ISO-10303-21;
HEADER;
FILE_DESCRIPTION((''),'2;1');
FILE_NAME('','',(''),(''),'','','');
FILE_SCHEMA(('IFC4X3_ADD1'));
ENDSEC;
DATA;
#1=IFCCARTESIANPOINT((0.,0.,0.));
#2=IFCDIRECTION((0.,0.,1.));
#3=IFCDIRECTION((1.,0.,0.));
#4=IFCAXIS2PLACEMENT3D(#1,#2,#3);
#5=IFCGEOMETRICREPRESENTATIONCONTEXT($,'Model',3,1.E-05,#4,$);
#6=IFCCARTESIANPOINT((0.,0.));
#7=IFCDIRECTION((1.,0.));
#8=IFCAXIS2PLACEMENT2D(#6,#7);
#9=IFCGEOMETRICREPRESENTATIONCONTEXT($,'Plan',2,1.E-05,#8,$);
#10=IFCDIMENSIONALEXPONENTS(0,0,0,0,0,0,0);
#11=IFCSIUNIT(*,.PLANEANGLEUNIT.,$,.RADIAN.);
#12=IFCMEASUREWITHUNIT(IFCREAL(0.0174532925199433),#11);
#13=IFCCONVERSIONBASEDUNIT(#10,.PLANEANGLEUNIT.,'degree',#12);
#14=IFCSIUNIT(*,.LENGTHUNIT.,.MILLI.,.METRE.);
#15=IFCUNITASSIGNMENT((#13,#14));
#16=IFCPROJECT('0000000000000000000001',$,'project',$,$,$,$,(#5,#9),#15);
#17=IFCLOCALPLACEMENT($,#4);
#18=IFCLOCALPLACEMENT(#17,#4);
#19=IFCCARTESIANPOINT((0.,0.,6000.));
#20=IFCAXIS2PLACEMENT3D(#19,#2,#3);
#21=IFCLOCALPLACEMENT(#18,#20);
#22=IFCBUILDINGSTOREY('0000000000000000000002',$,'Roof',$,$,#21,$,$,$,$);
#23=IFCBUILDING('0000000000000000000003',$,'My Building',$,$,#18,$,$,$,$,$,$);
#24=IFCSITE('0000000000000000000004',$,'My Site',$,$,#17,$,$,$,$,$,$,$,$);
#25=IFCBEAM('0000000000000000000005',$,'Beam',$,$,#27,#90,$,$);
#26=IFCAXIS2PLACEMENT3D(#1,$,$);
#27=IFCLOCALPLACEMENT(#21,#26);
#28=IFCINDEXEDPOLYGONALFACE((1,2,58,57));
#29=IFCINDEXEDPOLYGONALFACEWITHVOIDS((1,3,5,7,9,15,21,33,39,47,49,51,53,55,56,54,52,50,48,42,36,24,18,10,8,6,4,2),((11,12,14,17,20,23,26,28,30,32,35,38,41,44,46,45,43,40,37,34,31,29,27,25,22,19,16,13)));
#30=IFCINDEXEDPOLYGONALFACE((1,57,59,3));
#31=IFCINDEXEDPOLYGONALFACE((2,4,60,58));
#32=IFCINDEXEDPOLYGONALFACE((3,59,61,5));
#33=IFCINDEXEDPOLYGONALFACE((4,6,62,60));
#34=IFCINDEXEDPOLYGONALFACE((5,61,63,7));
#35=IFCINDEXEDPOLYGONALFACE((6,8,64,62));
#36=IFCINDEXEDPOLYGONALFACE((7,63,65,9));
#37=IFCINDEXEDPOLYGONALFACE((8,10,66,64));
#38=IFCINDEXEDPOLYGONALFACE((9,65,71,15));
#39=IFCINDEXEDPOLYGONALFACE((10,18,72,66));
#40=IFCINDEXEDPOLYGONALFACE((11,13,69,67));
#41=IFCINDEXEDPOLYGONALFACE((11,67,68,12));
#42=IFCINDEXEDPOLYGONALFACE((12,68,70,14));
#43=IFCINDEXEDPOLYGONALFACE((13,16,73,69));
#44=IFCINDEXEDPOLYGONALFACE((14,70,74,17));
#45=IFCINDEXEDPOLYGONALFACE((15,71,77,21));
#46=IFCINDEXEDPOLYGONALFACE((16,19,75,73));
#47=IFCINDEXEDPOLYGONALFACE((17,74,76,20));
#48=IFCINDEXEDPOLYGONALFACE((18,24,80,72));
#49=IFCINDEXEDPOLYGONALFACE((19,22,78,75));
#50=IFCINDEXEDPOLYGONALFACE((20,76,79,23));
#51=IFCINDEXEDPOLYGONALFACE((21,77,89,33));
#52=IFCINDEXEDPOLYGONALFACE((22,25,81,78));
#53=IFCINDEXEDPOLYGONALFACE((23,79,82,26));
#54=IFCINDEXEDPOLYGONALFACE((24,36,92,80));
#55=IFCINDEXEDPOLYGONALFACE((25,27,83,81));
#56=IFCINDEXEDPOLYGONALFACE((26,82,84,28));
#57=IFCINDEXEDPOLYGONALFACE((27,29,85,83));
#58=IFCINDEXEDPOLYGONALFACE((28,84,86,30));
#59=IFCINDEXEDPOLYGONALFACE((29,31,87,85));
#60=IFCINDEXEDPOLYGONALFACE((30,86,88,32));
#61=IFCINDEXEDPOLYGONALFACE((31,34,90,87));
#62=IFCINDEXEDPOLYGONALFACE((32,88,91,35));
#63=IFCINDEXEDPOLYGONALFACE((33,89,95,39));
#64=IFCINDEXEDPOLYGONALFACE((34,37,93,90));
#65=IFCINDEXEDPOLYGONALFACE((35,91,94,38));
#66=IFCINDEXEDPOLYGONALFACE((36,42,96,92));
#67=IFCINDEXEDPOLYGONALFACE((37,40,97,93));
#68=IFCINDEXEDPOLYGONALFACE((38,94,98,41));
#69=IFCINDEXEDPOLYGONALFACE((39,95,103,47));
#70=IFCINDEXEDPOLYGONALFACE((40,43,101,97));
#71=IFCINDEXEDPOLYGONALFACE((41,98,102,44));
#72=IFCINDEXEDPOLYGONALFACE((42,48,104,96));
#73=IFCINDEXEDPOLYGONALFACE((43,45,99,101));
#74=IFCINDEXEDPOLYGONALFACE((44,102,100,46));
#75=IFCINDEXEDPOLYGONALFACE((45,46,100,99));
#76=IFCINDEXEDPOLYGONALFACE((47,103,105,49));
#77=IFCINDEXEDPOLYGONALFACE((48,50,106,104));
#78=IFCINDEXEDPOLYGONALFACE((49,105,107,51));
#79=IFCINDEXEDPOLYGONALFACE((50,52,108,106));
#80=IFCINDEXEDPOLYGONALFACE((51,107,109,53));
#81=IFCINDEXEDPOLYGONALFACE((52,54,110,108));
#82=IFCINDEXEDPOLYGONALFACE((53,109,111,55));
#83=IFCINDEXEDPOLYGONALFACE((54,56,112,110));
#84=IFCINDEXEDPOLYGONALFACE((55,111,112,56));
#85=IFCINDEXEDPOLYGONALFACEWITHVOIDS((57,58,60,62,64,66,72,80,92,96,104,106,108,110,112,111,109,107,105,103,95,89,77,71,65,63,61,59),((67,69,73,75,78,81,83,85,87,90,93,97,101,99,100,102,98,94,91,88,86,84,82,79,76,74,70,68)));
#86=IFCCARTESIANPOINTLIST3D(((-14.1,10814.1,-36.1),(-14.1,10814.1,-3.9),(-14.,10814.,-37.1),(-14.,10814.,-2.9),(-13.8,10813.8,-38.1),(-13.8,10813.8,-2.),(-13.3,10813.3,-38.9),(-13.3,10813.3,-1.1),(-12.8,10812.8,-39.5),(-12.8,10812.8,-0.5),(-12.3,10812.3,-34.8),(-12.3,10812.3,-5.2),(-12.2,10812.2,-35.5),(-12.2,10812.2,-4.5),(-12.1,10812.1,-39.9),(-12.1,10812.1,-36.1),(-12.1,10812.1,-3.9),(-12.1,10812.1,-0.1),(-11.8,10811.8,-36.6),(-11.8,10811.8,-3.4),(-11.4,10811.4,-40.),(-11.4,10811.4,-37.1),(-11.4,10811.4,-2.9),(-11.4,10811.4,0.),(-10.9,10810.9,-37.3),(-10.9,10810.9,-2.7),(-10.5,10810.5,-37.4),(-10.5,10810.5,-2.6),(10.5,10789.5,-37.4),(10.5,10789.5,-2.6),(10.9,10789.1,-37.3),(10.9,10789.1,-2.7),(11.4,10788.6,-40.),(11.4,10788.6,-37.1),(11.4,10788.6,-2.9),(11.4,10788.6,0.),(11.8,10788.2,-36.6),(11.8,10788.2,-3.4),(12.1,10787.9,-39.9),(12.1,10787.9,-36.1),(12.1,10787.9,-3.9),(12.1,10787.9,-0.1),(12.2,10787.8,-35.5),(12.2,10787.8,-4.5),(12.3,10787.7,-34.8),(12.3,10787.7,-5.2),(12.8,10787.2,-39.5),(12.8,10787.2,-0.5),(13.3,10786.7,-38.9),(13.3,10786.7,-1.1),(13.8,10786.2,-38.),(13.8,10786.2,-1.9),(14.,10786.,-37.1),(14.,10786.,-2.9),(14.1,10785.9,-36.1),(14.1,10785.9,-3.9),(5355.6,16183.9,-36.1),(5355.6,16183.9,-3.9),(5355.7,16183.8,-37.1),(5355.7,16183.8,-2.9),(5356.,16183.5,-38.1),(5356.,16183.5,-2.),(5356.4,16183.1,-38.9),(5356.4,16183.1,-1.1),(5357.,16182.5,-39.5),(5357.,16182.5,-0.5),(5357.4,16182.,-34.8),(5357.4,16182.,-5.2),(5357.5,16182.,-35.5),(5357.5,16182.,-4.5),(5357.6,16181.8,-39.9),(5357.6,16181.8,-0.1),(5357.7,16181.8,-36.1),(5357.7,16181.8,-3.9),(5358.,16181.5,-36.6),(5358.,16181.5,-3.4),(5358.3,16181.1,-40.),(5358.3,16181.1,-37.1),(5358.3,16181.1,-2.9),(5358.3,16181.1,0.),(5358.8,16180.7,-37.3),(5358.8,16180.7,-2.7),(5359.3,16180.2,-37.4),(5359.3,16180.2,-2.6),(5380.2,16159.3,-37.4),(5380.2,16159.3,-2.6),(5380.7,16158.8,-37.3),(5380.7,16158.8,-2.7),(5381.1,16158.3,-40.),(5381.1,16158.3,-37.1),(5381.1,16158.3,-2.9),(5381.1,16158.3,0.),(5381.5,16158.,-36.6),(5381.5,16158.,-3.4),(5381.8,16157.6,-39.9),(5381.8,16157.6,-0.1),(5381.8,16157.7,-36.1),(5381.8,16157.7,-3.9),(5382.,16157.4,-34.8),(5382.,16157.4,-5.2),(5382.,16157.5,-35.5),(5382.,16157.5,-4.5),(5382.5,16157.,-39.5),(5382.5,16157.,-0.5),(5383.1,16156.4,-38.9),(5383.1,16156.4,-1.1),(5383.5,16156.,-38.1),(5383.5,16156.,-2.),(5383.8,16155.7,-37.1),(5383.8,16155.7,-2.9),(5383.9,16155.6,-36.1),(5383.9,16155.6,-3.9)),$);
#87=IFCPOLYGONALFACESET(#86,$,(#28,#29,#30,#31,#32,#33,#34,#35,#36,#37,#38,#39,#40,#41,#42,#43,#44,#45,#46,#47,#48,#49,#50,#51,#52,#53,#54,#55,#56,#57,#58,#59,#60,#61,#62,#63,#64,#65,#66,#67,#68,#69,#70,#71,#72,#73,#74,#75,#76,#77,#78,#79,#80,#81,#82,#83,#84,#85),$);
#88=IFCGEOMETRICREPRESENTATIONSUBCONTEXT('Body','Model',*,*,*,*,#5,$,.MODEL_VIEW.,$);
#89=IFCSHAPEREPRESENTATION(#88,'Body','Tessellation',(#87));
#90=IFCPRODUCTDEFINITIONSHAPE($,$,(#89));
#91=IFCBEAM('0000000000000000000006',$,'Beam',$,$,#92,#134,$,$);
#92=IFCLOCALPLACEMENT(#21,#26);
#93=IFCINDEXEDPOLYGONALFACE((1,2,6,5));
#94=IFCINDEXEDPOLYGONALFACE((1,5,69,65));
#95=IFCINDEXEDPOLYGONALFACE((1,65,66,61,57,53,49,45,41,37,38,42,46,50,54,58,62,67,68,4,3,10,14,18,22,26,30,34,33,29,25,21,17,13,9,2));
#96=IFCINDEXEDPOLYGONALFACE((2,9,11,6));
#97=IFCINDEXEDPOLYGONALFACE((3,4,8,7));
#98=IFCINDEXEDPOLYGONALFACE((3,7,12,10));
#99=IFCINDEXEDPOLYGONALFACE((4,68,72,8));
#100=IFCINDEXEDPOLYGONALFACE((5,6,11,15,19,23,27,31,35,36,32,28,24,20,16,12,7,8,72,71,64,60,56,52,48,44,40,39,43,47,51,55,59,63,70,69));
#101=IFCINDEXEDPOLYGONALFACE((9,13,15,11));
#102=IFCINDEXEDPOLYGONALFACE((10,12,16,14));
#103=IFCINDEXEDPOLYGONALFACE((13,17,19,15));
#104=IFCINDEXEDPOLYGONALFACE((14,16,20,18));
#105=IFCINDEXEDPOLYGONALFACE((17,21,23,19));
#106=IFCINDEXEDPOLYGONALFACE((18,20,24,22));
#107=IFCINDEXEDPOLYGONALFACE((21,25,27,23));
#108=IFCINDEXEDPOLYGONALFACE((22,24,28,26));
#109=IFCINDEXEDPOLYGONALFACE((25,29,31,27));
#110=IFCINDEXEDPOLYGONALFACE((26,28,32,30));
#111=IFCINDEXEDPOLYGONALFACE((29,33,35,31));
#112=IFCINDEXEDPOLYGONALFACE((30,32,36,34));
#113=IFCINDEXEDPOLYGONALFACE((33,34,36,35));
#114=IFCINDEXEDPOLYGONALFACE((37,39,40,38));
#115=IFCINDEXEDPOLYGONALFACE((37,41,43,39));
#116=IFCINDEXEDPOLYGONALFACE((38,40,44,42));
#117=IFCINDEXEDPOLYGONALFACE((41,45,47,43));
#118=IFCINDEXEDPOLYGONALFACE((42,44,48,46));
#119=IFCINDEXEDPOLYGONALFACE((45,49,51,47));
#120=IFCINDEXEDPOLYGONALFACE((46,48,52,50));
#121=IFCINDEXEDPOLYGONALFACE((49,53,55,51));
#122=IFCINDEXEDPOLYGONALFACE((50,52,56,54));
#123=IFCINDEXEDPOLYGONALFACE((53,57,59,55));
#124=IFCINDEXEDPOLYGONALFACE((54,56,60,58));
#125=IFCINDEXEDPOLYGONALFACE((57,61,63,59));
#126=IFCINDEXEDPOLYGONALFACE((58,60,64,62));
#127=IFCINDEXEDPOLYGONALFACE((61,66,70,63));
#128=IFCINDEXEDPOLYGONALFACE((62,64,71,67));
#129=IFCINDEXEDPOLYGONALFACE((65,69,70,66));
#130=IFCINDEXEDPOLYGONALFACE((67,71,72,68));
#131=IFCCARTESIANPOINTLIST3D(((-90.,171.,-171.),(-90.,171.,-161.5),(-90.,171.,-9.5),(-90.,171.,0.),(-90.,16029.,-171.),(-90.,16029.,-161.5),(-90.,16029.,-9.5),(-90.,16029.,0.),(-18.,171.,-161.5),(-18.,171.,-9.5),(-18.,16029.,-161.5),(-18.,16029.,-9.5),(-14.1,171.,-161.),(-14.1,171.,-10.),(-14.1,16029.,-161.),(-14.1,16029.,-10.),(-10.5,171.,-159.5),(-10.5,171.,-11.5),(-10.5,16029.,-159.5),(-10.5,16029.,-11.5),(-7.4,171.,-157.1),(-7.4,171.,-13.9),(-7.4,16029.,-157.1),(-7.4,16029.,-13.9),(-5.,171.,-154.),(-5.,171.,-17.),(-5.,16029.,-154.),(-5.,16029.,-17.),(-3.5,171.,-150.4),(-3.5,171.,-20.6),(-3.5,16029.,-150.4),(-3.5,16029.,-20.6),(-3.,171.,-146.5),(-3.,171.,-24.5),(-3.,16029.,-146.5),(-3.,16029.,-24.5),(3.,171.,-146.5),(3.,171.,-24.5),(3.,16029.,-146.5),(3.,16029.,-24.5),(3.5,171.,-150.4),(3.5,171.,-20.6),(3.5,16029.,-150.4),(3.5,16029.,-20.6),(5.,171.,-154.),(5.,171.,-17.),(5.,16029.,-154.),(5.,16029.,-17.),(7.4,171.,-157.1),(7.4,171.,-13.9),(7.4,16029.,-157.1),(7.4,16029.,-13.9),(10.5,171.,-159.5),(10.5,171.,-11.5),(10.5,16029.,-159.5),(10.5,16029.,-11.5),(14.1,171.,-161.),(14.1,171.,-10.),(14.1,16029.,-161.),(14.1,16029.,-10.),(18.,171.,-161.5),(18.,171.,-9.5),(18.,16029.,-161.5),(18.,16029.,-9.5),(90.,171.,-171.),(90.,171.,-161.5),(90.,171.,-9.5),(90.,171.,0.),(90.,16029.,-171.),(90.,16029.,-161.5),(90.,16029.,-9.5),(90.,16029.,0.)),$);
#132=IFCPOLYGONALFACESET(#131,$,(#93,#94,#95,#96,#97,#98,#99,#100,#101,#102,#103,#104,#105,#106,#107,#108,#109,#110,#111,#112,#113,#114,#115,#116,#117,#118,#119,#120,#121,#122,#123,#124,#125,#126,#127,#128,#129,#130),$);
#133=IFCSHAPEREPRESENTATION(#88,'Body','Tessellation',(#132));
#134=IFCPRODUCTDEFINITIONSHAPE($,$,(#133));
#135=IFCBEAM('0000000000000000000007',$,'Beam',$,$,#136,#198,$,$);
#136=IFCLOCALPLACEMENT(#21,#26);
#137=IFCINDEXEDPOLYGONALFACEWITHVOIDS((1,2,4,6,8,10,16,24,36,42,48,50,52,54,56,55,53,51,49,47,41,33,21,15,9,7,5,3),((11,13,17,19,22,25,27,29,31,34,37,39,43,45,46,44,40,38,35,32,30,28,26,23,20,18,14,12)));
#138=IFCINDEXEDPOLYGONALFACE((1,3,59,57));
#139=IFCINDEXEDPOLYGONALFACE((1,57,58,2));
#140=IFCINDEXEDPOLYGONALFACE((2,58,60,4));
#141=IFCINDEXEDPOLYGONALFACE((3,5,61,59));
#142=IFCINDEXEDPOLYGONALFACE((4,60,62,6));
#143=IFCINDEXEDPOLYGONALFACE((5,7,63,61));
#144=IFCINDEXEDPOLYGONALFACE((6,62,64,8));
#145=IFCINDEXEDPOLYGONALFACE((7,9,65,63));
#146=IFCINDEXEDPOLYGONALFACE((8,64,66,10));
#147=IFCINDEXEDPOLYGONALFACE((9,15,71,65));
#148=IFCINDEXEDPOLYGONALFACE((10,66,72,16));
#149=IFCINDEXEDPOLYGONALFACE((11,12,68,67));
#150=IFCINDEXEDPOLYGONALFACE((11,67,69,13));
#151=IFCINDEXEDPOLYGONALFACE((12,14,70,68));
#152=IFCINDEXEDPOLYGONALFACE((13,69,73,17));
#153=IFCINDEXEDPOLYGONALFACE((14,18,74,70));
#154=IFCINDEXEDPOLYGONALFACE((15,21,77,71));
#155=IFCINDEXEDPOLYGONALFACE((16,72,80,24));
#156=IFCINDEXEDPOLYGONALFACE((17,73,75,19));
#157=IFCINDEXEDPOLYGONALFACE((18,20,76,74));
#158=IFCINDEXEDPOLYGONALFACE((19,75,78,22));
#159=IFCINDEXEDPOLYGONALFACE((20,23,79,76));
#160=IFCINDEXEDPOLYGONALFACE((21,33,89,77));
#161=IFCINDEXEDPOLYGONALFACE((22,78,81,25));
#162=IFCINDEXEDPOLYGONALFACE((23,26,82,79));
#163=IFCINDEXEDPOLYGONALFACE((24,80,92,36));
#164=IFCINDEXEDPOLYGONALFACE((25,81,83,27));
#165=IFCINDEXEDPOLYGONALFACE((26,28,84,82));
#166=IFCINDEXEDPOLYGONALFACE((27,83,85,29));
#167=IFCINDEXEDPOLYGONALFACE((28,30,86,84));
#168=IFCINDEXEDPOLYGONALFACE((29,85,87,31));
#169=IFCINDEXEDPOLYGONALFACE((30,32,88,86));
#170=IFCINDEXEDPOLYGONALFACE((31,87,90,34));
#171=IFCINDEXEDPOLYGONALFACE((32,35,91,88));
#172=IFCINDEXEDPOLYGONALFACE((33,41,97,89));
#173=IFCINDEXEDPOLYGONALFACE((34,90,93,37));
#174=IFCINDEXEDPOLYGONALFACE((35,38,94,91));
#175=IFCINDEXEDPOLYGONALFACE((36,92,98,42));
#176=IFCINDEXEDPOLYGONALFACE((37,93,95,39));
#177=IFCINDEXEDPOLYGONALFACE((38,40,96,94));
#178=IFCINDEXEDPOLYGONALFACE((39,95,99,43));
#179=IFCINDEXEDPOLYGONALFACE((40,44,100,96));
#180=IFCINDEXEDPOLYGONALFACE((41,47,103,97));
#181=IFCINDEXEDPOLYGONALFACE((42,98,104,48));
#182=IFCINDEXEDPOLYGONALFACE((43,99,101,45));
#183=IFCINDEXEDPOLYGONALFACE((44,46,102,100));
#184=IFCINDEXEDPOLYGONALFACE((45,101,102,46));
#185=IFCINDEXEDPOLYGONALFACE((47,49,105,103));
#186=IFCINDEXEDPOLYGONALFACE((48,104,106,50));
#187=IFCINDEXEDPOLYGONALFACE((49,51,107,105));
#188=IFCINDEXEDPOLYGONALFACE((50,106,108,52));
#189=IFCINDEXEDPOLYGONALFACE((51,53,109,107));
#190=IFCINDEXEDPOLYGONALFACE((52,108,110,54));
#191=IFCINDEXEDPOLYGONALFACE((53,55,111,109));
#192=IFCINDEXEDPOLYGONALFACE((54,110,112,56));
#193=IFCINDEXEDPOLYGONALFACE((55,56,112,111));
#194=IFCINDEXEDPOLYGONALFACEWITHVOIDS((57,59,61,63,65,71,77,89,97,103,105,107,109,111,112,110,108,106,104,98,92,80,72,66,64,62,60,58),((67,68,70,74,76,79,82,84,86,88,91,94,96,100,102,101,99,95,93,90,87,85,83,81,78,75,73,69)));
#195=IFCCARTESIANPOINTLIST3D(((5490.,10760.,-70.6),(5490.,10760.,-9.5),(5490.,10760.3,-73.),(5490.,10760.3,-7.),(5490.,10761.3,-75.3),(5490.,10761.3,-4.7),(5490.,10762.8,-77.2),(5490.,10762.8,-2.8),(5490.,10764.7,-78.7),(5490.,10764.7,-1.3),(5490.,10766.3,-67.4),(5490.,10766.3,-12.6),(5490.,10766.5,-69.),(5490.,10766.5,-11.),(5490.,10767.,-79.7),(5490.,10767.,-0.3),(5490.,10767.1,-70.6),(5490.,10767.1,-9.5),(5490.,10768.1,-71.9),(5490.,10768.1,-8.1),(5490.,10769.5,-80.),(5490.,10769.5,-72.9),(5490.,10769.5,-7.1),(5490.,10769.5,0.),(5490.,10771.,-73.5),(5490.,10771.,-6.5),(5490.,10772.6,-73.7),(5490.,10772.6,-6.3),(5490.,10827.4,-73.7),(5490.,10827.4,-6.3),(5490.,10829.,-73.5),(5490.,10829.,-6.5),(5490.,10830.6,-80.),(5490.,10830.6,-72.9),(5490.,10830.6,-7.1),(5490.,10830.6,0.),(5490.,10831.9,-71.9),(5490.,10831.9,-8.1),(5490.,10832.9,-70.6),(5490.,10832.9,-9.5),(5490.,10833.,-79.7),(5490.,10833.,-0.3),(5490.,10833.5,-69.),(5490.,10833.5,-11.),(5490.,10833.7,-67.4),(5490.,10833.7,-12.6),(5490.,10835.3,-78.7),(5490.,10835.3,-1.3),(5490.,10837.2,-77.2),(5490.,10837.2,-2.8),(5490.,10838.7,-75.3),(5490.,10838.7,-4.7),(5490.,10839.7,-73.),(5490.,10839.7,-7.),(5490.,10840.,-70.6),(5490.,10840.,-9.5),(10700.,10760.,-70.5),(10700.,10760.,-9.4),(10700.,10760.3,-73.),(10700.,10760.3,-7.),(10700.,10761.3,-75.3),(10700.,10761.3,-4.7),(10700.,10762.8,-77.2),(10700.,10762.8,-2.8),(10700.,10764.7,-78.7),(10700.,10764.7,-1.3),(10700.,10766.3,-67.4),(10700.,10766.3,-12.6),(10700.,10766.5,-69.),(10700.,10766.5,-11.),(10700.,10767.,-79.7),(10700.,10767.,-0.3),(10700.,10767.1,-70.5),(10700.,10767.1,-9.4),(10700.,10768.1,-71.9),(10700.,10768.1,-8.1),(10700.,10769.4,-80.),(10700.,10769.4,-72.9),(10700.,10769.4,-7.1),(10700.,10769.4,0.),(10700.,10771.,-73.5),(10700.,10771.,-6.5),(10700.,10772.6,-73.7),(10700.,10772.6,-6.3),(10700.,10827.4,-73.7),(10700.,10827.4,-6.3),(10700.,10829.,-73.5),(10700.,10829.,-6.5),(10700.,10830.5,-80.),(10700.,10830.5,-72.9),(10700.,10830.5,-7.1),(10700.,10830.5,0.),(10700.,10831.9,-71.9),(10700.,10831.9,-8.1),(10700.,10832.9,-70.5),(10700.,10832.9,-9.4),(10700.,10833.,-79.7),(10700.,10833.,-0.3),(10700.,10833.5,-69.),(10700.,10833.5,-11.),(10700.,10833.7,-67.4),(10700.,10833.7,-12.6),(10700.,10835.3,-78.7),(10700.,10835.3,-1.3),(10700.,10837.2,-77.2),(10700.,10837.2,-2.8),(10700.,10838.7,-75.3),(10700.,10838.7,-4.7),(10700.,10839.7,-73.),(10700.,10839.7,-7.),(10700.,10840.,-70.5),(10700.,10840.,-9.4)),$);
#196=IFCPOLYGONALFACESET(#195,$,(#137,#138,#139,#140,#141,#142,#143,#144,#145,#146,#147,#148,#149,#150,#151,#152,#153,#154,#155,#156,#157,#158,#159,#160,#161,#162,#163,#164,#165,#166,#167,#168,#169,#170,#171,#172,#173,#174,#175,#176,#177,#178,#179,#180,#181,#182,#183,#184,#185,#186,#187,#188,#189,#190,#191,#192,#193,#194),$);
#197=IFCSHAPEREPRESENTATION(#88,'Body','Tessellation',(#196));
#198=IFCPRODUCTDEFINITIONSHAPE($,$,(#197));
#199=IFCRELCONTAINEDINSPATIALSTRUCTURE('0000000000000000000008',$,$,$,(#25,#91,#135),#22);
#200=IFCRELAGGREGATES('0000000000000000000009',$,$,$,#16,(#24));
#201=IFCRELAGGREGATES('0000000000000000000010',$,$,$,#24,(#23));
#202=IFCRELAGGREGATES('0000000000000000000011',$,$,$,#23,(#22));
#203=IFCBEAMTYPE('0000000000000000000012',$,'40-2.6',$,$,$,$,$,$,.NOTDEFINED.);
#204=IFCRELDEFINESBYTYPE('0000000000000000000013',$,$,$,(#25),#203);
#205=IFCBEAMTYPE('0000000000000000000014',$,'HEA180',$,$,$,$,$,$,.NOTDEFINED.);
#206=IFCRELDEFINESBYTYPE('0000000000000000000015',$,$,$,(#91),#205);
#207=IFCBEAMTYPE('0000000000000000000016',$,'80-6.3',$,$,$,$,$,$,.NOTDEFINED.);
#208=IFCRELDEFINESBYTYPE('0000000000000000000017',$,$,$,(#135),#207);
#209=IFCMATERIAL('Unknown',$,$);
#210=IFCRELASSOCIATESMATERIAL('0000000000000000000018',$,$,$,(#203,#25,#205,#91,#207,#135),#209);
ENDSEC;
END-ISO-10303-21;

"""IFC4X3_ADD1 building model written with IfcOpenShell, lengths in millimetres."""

from ifc_helpers import new_model, entity, si_unit, converted_unit, frame, origin_with_axes, origin_2d_with_axis, place, context, subcontext, project, spatial, hollow_rectangle, i_section, extrude, material, material_profile, profile_set, profile_usage, type_object, element, save


model = new_model("IFC4X3_ADD1")

# Units and contexts
model_context = context("Model", 3, precision=1e-05, world=origin_with_axes())
plan_context = context("Plan", 2, precision=1e-05, world=origin_2d_with_axis())
body_context = subcontext(model_context, "Body", "Model", "MODEL_VIEW")
ifc_project = project(units=[converted_unit("PLANEANGLEUNIT", "degree", entity("IfcReal", 0.0174532925199433), si_unit("PLANEANGLEUNIT", "RADIAN"), dimensions=[0, 0, 0, 0, 0, 0, 0]), si_unit("LENGTHUNIT", "METRE", prefix="MILLI")], contexts=[model_context, plan_context])

# Site, building, storey
site_placement = place(None, origin_with_axes())
site = spatial("IfcSite", under=ifc_project, at=site_placement, Name="My Site")
building_placement = place(site_placement, origin_with_axes())
building = spatial("IfcBuilding", under=site, at=building_placement, Name="My Building")
storey_placement = place(building_placement, frame((0.0, 0.0, 6000.0), z_axis=(0.0, 0.0, 1.0), x_axis=(1.0, 0.0, 0.0)))
storey = spatial("IfcBuildingStorey", under=building, at=storey_placement, Name="Roof")

# Beams
ifc_material = material(Name="Unknown")
ifc_material_profile_1 = material_profile(ifc_material, hollow_rectangle(XDim=40.0, YDim=40.0, WallThickness=2.6, InnerFilletRadius=2.6, OuterFilletRadius=3.9))
ifc_profile_set_1 = profile_set([ifc_material_profile_1])
beam_type_1 = type_object("IfcBeamType", Name="40-2.6", PredefinedType="NOTDEFINED", material=ifc_profile_set_1)
ifc_profile_usage_1 = profile_usage(ifc_profile_set_1, cardinal=8)
beam_1_placement = place(storey_placement, frame((0.0, 10800.0, 0.0), z_axis=(0.707107, 0.707107, 0.0), x_axis=(-0.707107, 0.707107, 0.0)))
element("IfcBeam", 1, at=beam_1_placement, inside=storey, type_object=beam_type_1, material=ifc_profile_usage_1, Name="Beam", context=body_context, shape_type="SweptSolid", body=[
    extrude(hollow_rectangle(XDim=40.0, YDim=40.0, WallThickness=2.6, InnerFilletRadius=2.6, OuterFilletRadius=3.9), frame((0.0, -20.0, 0.0), z_axis=(0.0, 0.0, 1.0), x_axis=(1.0, 0.0, 0.0)), (0.0, 0.0, 1.0), 7594.0),
])
ifc_material_profile_2 = material_profile(ifc_material, i_section(OverallWidth=180.0, OverallDepth=171.0, WebThickness=6.0, FlangeThickness=9.5, FilletRadius=15.0))
ifc_profile_set_2 = profile_set([ifc_material_profile_2])
ifc_profile_usage_2 = profile_usage(ifc_profile_set_2, cardinal=8)
beam_type_2 = type_object("IfcBeamType", Name="HEA180", PredefinedType="NOTDEFINED", material=ifc_profile_set_2)
beam_2_placement = place(storey_placement, frame((0.0, 171.0, 0.0), z_axis=(0.000001, 1.0, 0.0), x_axis=(-1.0, 0.000001, 0.0)))
element("IfcBeam", 2, at=beam_2_placement, inside=storey, type_object=beam_type_2, material=ifc_profile_usage_2, Name="Beam", context=body_context, shape_type="SweptSolid", body=[
    extrude(i_section(OverallWidth=180.0, OverallDepth=171.0, WebThickness=6.0, FlangeThickness=9.5, FilletRadius=15.0), frame((0.0, -85.5, 0.0), z_axis=(0.0, 0.0, 1.0), x_axis=(1.0, 0.0, 0.0)), (0.0, 0.0, 1.0), 15858.0),
])
ifc_material_profile_3 = material_profile(ifc_material, hollow_rectangle(XDim=80.0, YDim=80.0, WallThickness=6.3, InnerFilletRadius=6.3, OuterFilletRadius=9.4))
ifc_profile_set_3 = profile_set([ifc_material_profile_3])
ifc_profile_usage_3 = profile_usage(ifc_profile_set_3, cardinal=8)
beam_type_3 = type_object("IfcBeamType", Name="80-6.3", PredefinedType="NOTDEFINED", material=ifc_profile_set_3)
beam_3_placement = place(storey_placement, frame((5490.0, 10800.0, 0.0), z_axis=(1.0, 0.0, 0.0), x_axis=(0.0, 1.0, 0.0)))
element("IfcBeam", 3, at=beam_3_placement, inside=storey, type_object=beam_type_3, material=ifc_profile_usage_3, Name="Beam", context=body_context, shape_type="SweptSolid", body=[
    extrude(hollow_rectangle(XDim=80.0, YDim=80.0, WallThickness=6.3, InnerFilletRadius=6.3, OuterFilletRadius=9.4), frame((0.0, -40.0, 0.0), z_axis=(0.0, 0.0, 1.0), x_axis=(1.0, 0.0, 0.0)), (0.0, 0.0, 1.0), 5210.0),
])

save(model, "model.ifc")
